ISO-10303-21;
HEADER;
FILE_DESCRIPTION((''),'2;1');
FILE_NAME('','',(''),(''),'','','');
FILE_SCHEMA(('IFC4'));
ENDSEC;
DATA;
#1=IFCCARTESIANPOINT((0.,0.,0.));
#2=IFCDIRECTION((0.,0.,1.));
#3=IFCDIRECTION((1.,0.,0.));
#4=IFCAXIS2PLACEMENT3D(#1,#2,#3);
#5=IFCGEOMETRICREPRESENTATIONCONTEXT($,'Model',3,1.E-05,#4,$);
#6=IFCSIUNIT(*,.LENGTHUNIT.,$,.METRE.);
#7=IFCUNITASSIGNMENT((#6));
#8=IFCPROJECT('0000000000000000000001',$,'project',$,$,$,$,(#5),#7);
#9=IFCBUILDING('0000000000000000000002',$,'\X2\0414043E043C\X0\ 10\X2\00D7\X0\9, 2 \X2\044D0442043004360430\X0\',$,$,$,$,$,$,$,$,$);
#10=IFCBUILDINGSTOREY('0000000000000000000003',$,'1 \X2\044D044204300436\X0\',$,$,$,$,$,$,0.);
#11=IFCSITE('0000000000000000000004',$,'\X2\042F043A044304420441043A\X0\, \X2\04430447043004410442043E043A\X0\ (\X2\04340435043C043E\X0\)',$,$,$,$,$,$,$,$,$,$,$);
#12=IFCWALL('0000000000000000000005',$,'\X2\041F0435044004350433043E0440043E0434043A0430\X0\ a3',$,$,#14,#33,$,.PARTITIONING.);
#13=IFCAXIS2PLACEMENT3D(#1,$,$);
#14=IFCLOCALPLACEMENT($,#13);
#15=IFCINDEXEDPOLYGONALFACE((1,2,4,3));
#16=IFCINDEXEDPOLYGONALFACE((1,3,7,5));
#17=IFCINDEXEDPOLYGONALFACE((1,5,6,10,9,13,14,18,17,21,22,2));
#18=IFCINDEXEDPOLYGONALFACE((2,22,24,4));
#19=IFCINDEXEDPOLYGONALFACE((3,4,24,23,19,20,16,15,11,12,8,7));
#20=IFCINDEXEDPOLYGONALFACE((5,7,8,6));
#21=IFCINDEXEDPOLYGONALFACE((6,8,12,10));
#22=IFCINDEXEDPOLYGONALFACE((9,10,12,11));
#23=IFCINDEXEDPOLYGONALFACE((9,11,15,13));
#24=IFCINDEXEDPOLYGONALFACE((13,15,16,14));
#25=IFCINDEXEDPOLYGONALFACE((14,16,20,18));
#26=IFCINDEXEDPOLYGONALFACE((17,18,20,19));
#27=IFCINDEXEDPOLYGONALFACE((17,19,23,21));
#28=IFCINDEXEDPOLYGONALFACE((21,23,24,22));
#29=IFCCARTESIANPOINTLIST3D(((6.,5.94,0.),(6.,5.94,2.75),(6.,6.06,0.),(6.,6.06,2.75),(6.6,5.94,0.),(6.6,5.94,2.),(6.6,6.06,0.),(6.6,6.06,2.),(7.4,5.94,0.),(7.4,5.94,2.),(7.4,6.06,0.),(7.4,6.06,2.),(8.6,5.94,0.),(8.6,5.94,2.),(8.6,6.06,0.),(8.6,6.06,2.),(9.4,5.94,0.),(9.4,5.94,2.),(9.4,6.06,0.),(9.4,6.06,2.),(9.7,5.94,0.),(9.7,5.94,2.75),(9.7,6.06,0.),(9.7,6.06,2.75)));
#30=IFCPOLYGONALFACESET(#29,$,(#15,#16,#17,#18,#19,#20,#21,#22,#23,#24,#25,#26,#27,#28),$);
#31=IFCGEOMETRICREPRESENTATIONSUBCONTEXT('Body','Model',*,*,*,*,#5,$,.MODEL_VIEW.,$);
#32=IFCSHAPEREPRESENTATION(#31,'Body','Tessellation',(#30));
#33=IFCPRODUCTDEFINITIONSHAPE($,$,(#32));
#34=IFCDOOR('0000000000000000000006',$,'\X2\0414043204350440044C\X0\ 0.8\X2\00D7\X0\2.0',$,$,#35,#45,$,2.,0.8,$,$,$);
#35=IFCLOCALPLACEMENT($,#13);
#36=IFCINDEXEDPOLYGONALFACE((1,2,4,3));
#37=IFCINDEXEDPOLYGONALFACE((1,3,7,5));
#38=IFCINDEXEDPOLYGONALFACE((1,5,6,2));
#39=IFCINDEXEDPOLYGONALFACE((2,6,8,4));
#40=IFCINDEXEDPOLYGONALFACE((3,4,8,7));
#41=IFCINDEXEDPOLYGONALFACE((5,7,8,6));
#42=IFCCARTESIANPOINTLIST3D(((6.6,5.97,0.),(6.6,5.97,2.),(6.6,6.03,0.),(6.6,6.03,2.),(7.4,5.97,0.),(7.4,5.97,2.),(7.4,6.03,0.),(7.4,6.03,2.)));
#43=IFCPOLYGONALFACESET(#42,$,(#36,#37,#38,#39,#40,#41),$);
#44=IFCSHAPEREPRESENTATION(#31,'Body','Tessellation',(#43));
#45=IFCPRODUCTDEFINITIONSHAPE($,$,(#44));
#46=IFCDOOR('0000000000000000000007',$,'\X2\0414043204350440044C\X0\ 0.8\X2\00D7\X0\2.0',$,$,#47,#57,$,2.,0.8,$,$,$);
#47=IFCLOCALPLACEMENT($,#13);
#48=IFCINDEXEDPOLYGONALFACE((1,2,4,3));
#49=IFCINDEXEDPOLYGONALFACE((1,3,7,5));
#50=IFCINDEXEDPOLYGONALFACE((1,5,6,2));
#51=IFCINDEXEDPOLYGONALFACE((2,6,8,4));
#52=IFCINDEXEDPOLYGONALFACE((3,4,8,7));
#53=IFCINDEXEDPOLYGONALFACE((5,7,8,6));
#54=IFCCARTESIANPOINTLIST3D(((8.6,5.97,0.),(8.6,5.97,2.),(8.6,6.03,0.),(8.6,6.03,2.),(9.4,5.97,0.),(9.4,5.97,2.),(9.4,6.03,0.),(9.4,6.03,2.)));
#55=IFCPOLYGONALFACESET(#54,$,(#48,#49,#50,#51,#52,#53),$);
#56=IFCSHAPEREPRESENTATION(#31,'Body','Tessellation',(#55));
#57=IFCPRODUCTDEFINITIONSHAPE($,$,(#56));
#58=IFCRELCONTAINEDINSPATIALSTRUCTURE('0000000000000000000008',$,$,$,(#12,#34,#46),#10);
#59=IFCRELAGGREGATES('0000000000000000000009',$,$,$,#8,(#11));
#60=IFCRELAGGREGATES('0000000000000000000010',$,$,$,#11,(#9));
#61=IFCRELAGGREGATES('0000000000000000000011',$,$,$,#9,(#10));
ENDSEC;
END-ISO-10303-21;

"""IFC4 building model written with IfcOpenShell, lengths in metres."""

from ifc_helpers import new_model, si_unit, frame, origin_with_axes, place, context, subcontext, project, spatial, indexed_curve, outline, extrude, element, fill, save


model = new_model("IFC4")

# Units and contexts
model_context = context("Model", 3, precision=1e-05, world=origin_with_axes())
body_context = subcontext(model_context, "Body", "Model", "MODEL_VIEW")
ifc_project = project(units=[si_unit("LENGTHUNIT", "METRE")], contexts=[model_context])

# Site, building, storey
site = spatial("IfcSite", under=ifc_project, Name="Якутск, участок (демо)")
building = spatial("IfcBuilding", under=site, Name="Дом 10×9, 2 этажа")
storey = spatial("IfcBuildingStorey", under=building, Name="1 этаж", Elevation=0.0)

# Wall, openings, doors
wall_1_placement = place(None, frame((6.0, 5.94, 0.0), z_axis=(0.0, 0.0, 1.0), x_axis=(1.0, 0.0, 0.0)))
wall_1 = element("IfcWall", 1, at=wall_1_placement, inside=storey, Name="Перегородка a3", PredefinedType="PARTITIONING", context=body_context, shape_type="SweptSolid", body=[
    extrude(outline(indexed_curve([(0.0, 0.0), (0.0, 0.12), (3.7, 0.12), (3.7, 0.0), (0.0, 0.0)], self_intersect=False)), origin_with_axes(), (0.0, 0.0, 1.0), 2.75),
])
opening_1_placement = place(wall_1_placement, frame((0.6, -0.05, 0.0), z_axis=(0.0, 0.0, 1.0), x_axis=(1.0, 0.0, 0.0)))
opening_1 = element("IfcOpeningElement", 2, at=opening_1_placement, cuts=wall_1, context=body_context, shape_type="SweptSolid", body=[
    extrude(outline(indexed_curve([(0.0, 0.0), (0.0, 0.22), (0.8, 0.22), (0.8, 0.0), (0.0, 0.0)], self_intersect=False)), origin_with_axes(), (0.0, 0.0, 1.0), 2.0),
])
opening_2_placement = place(wall_1_placement, frame((2.6, -0.05, 0.0), z_axis=(0.0, 0.0, 1.0), x_axis=(1.0, 0.0, 0.0)))
opening_2 = element("IfcOpeningElement", 3, at=opening_2_placement, cuts=wall_1, context=body_context, shape_type="SweptSolid", body=[
    extrude(outline(indexed_curve([(0.0, 0.0), (0.0, 0.22), (0.8, 0.22), (0.8, 0.0), (0.0, 0.0)], self_intersect=False)), origin_with_axes(), (0.0, 0.0, 1.0), 2.0),
])
door_1_placement = place(opening_1_placement, frame((0.0, 0.08, 0.0), z_axis=(0.0, 0.0, 1.0), x_axis=(1.0, 0.0, 0.0)))
door_1 = element("IfcDoor", 4, at=door_1_placement, inside=storey, Name="Дверь 0.8×2.0", OverallHeight=2.0, OverallWidth=0.8, context=body_context, shape_type="SweptSolid", body=[
    extrude(outline(indexed_curve([(0.0, 0.0), (0.0, 0.06), (0.8, 0.06), (0.8, 0.0), (0.0, 0.0)], self_intersect=False)), origin_with_axes(), (0.0, 0.0, 1.0), 2.0),
])
fill(opening_1, door_1)
door_2_placement = place(opening_2_placement, frame((0.0, 0.08, 0.0), z_axis=(0.0, 0.0, 1.0), x_axis=(1.0, 0.0, 0.0)))
door_2 = element("IfcDoor", 5, at=door_2_placement, inside=storey, Name="Дверь 0.8×2.0", OverallHeight=2.0, OverallWidth=0.8, context=body_context, shape_type="SweptSolid", body=[
    extrude(outline(indexed_curve([(0.0, 0.0), (0.0, 0.06), (0.8, 0.06), (0.8, 0.0), (0.0, 0.0)], self_intersect=False)), origin_with_axes(), (0.0, 0.0, 1.0), 2.0),
])
fill(opening_2, door_2)

save(model, "model.ifc")
